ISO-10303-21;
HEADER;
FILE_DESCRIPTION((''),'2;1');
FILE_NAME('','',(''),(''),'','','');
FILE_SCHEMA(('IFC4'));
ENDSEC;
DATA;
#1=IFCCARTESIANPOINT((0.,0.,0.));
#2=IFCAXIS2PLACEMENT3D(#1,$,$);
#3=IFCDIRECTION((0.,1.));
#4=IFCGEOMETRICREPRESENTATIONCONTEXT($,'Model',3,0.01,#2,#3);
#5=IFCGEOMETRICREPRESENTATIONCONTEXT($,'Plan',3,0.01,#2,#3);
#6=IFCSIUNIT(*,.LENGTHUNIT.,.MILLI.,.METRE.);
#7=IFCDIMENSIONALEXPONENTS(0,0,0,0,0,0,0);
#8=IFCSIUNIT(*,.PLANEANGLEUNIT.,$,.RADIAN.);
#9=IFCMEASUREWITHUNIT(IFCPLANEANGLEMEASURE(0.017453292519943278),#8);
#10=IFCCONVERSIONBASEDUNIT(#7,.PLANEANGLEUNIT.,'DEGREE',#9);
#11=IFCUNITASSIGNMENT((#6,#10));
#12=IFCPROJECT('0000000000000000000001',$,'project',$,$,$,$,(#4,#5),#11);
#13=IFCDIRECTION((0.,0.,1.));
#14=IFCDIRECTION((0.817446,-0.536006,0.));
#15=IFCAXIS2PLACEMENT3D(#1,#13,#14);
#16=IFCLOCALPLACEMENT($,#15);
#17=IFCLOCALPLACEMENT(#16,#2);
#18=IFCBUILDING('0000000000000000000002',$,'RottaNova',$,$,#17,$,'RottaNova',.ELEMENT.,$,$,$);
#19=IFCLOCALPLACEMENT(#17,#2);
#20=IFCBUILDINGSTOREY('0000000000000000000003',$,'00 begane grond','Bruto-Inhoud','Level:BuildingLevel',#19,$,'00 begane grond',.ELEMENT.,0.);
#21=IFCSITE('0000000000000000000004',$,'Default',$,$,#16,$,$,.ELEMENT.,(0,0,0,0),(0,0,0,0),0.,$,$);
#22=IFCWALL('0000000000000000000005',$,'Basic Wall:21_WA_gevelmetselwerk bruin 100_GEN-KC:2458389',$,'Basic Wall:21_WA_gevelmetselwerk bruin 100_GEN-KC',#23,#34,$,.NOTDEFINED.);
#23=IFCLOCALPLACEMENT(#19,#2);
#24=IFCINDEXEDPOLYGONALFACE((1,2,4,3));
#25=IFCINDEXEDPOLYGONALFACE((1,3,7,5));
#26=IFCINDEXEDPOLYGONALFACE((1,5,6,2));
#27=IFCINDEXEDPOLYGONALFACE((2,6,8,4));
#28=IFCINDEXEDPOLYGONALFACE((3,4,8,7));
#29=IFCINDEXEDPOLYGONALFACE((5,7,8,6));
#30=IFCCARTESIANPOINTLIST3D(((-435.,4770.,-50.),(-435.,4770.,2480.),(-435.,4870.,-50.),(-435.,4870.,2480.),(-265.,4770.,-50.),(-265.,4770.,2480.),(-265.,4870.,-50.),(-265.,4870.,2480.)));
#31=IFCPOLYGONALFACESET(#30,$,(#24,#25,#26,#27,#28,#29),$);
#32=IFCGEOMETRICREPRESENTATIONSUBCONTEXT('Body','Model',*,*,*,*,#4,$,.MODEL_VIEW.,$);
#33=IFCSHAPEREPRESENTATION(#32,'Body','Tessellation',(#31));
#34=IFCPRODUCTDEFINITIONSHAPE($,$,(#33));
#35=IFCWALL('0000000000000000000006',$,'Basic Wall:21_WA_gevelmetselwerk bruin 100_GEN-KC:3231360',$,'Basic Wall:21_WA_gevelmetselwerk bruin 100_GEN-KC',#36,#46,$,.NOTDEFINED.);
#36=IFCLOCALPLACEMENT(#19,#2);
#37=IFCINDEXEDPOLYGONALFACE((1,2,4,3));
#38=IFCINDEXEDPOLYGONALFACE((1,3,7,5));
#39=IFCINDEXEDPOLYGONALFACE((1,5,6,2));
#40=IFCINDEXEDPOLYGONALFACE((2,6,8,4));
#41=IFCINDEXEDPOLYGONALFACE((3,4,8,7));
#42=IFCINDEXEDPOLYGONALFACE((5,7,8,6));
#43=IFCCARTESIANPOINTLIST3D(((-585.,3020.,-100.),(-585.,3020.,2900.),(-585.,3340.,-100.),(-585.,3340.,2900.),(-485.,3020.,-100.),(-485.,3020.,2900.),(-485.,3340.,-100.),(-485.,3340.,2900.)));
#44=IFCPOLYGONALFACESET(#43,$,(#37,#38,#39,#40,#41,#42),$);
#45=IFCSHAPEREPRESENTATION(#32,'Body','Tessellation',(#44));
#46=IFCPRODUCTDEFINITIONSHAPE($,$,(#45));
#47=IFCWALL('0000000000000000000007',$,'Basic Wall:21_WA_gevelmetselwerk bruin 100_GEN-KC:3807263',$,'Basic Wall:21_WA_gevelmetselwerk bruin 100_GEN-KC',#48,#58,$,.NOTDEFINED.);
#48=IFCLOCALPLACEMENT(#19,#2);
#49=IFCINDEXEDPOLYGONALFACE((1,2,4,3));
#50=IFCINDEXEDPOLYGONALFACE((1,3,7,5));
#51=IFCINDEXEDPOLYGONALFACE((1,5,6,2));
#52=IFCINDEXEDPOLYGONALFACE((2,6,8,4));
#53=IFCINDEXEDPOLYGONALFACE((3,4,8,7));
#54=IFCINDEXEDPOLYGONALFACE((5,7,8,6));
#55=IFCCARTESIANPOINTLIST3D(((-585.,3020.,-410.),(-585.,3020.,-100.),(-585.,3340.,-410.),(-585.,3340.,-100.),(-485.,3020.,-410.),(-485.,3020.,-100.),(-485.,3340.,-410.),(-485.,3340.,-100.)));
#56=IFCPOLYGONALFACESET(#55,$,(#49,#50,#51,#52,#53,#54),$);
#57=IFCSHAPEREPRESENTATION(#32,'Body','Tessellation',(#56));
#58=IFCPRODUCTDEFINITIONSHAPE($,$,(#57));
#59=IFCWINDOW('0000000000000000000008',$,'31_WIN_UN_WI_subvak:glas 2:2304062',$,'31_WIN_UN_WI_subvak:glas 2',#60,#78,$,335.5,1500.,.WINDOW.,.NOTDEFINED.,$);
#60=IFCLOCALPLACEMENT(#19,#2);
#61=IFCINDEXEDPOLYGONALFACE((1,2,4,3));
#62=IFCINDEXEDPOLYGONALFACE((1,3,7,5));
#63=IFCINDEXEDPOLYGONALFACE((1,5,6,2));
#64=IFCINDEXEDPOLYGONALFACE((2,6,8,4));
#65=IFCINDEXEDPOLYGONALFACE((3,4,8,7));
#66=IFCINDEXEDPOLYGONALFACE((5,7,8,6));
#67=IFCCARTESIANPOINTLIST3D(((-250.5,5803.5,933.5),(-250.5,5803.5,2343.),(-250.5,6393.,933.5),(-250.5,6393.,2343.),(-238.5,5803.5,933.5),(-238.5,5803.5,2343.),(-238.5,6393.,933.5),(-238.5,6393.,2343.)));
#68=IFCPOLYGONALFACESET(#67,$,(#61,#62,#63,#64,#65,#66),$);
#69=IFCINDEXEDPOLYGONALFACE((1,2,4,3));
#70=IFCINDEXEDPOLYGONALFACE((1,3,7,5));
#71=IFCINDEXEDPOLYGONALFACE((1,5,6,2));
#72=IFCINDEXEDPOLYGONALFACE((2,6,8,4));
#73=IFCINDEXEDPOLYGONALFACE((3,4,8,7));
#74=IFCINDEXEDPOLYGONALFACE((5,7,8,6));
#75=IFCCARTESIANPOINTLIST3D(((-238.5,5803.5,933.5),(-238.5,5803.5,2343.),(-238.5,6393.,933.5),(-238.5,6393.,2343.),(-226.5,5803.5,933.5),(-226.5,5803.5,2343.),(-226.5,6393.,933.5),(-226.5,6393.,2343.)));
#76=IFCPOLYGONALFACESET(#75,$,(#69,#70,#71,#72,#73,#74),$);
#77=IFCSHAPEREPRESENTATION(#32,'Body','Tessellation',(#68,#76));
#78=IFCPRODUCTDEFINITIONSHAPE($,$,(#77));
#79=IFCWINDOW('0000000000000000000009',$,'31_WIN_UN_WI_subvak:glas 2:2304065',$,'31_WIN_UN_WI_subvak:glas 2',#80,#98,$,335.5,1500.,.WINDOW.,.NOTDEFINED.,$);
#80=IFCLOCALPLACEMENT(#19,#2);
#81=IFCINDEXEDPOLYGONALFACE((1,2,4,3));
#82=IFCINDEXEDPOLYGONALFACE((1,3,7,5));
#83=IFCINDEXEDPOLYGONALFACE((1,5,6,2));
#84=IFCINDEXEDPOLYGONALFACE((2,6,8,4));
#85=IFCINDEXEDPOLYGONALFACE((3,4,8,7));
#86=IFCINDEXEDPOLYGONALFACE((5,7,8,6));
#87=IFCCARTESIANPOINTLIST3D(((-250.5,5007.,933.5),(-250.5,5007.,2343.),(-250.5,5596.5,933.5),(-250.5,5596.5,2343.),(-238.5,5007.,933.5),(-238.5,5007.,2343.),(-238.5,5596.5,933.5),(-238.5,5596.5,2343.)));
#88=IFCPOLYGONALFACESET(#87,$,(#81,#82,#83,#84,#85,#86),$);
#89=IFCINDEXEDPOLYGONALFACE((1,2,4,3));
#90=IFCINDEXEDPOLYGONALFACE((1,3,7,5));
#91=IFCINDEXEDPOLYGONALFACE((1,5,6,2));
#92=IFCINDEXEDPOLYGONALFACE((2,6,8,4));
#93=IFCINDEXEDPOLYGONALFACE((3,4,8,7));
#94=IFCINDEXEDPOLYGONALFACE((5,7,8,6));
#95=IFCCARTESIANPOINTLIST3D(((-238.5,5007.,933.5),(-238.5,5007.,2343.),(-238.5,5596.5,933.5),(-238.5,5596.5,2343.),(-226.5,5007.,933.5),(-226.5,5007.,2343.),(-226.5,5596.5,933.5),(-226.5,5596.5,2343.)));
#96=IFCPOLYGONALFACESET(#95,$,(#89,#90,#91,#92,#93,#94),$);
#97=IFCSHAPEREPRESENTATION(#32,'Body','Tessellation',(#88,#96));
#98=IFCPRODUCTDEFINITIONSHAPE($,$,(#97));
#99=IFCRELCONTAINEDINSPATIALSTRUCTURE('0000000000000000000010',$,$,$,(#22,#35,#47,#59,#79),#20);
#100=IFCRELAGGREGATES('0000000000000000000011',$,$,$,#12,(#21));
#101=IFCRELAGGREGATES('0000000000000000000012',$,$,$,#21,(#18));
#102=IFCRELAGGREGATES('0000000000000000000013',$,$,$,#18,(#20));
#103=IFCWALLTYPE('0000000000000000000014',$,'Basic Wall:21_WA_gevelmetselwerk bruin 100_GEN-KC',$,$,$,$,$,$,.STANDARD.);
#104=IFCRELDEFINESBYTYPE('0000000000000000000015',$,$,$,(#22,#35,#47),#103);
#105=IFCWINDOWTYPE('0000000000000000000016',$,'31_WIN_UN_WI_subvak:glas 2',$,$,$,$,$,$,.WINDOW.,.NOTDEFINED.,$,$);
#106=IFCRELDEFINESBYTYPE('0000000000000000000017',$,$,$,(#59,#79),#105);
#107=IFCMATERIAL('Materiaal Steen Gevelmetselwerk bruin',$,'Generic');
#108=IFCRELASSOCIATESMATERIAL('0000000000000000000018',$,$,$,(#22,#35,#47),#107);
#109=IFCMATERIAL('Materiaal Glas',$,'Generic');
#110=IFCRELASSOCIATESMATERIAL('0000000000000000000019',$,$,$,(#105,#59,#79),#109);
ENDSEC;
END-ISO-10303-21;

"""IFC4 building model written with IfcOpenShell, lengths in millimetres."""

from ifc_helpers import new_model, entity, si_unit, converted_unit, direction, frame, origin, place, context, subcontext, project, spatial, indexed_curve, outline, extrude, source, transform, mapped, material, type_object, type_shapes, element, save


model = new_model("IFC4")

# Units and contexts
model_context = context("Model", 3, precision=0.01, world=origin(), true_north=direction((0.0, 1.0)))
plan_context = context("Plan", 3, precision=0.01, world=origin(), true_north=direction((0.0, 1.0)))
body_context = subcontext(model_context, "Body", "Model", "MODEL_VIEW")
ifc_project = project(units=[si_unit("LENGTHUNIT", "METRE", prefix="MILLI"), converted_unit("PLANEANGLEUNIT", "DEGREE", entity("IfcPlaneAngleMeasure", 0.017453292519943278), si_unit("PLANEANGLEUNIT", "RADIAN"), dimensions=[0, 0, 0, 0, 0, 0, 0])], contexts=[model_context, plan_context])

# Site, building, storey
site_placement = place(None, frame((0.0, 0.0, 0.0), z_axis=(0.0, 0.0, 1.0), x_axis=(0.817446, -0.536006, 0.0)))
site = spatial("IfcSite", under=ifc_project, at=site_placement, Name="Default", CompositionType="ELEMENT", RefLatitude=(0, 0, 0, 0), RefLongitude=(0, 0, 0, 0), RefElevation=0.0)
building_placement = place(site_placement, origin())
building = spatial("IfcBuilding", under=site, at=building_placement, Name="RottaNova", LongName="RottaNova", CompositionType="ELEMENT")
storey_placement = place(building_placement, origin())
storey = spatial("IfcBuildingStorey", under=building, at=storey_placement, Name="00 begane grond", Description="Bruto-Inhoud", ObjectType="Level:BuildingLevel", LongName="00 begane grond", CompositionType="ELEMENT", Elevation=0.0)

# Shared definitions
ifc_material_1 = material(Name="Materiaal Glas", Category="Generic")

# Walls
ifc_material_2 = material(Name="Materiaal Steen Gevelmetselwerk bruin", Category="Generic")
wall_type_1 = type_object("IfcWallType", Name="Basic Wall:21_WA_gevelmetselwerk bruin 100_GEN-KC", PredefinedType="STANDARD")
wall_1_placement = place(storey_placement, frame((-435.0, 4820.0, -50.0)))
element("IfcWall", 1, at=wall_1_placement, inside=storey, type_object=wall_type_1, material=ifc_material_2, Name="Basic Wall:21_WA_gevelmetselwerk bruin 100_GEN-KC:2458389", ObjectType="Basic Wall:21_WA_gevelmetselwerk bruin 100_GEN-KC", PredefinedType="NOTDEFINED", context=body_context, shape_type="SweptSolid", body=[
    extrude(outline(indexed_curve([(170.0, 50.0), (0.0, 50.0), (0.0, -50.0), (170.0, -50.0), (170.0, 50.0)], self_intersect=False)), origin(), (0.0, 0.0, 1.0), 2530.0),
])
wall_2_placement = place(storey_placement, frame((-535.0, 3340.0, -100.0), z_axis=(0.0, 0.0, 1.0), x_axis=(0.0, -1.0, 0.0)))
element("IfcWall", 2, at=wall_2_placement, inside=storey, type_object=wall_type_1, material=ifc_material_2, Name="Basic Wall:21_WA_gevelmetselwerk bruin 100_GEN-KC:3231360", ObjectType="Basic Wall:21_WA_gevelmetselwerk bruin 100_GEN-KC", PredefinedType="NOTDEFINED", context=body_context, shape_type="SweptSolid", body=[
    extrude(outline(indexed_curve([(320.0, 50.0), (0.0, 50.0), (0.0, -50.0), (320.0, -50.0), (320.0, 50.0)], self_intersect=False)), origin(), (0.0, 0.0, 1.0), 3000.0),
])
wall_3_placement = place(storey_placement, frame((-535.0, 3340.0, -410.0), z_axis=(0.0, 0.0, 1.0), x_axis=(0.0, -1.0, 0.0)))
element("IfcWall", 3, at=wall_3_placement, inside=storey, type_object=wall_type_1, material=ifc_material_2, Name="Basic Wall:21_WA_gevelmetselwerk bruin 100_GEN-KC:3807263", ObjectType="Basic Wall:21_WA_gevelmetselwerk bruin 100_GEN-KC", PredefinedType="NOTDEFINED", context=body_context, shape_type="SweptSolid", body=[
    extrude(outline(indexed_curve([(320.0, 50.0), (0.0, 50.0), (0.0, -50.0), (320.0, -50.0), (320.0, 50.0)], self_intersect=False)), origin(), (0.0, 0.0, 1.0), 310.0),
])

# Windows
window_type = type_object("IfcWindowType", Name="31_WIN_UN_WI_subvak:glas 2", PartitioningType="NOTDEFINED", PredefinedType="WINDOW", material=ifc_material_1)
shared_shape_1 = source(origin(), body_context, "Body", "SweptSolid", [
    extrude(outline(indexed_curve([(-294.7, -6.0), (294.7, -6.0), (294.7, 6.0), (-294.7, 6.0), (-294.7, -6.0)], self_intersect=False)), frame((0.0, -6.0, 0.0)), (0.0, 0.0, 1.0), 1409.5),
    extrude(outline(indexed_curve([(-294.8, -6.0), (294.8, -6.0), (294.8, 6.0), (-294.8, 6.0), (-294.8, -6.0)], self_intersect=False)), frame((0.0, 6.0, 0.0)), (0.0, 0.0, 1.0), 1409.5),
])
type_shapes(window_type, [shared_shape_1])
for number, where, z_axis, x_axis, name in (
    (4, (-238.5, 6098.2, 933.5), (0.0, 0.0, 1.0), (0.0, -1.0, 0.0), "31_WIN_UN_WI_subvak:glas 2:2304062"),
    (5, (-238.5, 5301.7, 933.5), (0.0, 0.0, 1.0), (0.0, -1.0, 0.0), "31_WIN_UN_WI_subvak:glas 2:2304065"),
):
    element("IfcWindow", number, at=place(storey_placement, frame(where, z_axis=z_axis, x_axis=x_axis)), inside=storey, type_object=window_type, material=ifc_material_1, Name=name, ObjectType="31_WIN_UN_WI_subvak:glas 2", OverallHeight=335.5, OverallWidth=1500.0, PartitioningType="NOTDEFINED", PredefinedType="WINDOW", context=body_context, shape_type="MappedRepresentation", body=[
        mapped(shared_shape_1, transform((0.0, 0.0, 0.0), scale=1.0)),
    ])

save(model, "model.ifc")
